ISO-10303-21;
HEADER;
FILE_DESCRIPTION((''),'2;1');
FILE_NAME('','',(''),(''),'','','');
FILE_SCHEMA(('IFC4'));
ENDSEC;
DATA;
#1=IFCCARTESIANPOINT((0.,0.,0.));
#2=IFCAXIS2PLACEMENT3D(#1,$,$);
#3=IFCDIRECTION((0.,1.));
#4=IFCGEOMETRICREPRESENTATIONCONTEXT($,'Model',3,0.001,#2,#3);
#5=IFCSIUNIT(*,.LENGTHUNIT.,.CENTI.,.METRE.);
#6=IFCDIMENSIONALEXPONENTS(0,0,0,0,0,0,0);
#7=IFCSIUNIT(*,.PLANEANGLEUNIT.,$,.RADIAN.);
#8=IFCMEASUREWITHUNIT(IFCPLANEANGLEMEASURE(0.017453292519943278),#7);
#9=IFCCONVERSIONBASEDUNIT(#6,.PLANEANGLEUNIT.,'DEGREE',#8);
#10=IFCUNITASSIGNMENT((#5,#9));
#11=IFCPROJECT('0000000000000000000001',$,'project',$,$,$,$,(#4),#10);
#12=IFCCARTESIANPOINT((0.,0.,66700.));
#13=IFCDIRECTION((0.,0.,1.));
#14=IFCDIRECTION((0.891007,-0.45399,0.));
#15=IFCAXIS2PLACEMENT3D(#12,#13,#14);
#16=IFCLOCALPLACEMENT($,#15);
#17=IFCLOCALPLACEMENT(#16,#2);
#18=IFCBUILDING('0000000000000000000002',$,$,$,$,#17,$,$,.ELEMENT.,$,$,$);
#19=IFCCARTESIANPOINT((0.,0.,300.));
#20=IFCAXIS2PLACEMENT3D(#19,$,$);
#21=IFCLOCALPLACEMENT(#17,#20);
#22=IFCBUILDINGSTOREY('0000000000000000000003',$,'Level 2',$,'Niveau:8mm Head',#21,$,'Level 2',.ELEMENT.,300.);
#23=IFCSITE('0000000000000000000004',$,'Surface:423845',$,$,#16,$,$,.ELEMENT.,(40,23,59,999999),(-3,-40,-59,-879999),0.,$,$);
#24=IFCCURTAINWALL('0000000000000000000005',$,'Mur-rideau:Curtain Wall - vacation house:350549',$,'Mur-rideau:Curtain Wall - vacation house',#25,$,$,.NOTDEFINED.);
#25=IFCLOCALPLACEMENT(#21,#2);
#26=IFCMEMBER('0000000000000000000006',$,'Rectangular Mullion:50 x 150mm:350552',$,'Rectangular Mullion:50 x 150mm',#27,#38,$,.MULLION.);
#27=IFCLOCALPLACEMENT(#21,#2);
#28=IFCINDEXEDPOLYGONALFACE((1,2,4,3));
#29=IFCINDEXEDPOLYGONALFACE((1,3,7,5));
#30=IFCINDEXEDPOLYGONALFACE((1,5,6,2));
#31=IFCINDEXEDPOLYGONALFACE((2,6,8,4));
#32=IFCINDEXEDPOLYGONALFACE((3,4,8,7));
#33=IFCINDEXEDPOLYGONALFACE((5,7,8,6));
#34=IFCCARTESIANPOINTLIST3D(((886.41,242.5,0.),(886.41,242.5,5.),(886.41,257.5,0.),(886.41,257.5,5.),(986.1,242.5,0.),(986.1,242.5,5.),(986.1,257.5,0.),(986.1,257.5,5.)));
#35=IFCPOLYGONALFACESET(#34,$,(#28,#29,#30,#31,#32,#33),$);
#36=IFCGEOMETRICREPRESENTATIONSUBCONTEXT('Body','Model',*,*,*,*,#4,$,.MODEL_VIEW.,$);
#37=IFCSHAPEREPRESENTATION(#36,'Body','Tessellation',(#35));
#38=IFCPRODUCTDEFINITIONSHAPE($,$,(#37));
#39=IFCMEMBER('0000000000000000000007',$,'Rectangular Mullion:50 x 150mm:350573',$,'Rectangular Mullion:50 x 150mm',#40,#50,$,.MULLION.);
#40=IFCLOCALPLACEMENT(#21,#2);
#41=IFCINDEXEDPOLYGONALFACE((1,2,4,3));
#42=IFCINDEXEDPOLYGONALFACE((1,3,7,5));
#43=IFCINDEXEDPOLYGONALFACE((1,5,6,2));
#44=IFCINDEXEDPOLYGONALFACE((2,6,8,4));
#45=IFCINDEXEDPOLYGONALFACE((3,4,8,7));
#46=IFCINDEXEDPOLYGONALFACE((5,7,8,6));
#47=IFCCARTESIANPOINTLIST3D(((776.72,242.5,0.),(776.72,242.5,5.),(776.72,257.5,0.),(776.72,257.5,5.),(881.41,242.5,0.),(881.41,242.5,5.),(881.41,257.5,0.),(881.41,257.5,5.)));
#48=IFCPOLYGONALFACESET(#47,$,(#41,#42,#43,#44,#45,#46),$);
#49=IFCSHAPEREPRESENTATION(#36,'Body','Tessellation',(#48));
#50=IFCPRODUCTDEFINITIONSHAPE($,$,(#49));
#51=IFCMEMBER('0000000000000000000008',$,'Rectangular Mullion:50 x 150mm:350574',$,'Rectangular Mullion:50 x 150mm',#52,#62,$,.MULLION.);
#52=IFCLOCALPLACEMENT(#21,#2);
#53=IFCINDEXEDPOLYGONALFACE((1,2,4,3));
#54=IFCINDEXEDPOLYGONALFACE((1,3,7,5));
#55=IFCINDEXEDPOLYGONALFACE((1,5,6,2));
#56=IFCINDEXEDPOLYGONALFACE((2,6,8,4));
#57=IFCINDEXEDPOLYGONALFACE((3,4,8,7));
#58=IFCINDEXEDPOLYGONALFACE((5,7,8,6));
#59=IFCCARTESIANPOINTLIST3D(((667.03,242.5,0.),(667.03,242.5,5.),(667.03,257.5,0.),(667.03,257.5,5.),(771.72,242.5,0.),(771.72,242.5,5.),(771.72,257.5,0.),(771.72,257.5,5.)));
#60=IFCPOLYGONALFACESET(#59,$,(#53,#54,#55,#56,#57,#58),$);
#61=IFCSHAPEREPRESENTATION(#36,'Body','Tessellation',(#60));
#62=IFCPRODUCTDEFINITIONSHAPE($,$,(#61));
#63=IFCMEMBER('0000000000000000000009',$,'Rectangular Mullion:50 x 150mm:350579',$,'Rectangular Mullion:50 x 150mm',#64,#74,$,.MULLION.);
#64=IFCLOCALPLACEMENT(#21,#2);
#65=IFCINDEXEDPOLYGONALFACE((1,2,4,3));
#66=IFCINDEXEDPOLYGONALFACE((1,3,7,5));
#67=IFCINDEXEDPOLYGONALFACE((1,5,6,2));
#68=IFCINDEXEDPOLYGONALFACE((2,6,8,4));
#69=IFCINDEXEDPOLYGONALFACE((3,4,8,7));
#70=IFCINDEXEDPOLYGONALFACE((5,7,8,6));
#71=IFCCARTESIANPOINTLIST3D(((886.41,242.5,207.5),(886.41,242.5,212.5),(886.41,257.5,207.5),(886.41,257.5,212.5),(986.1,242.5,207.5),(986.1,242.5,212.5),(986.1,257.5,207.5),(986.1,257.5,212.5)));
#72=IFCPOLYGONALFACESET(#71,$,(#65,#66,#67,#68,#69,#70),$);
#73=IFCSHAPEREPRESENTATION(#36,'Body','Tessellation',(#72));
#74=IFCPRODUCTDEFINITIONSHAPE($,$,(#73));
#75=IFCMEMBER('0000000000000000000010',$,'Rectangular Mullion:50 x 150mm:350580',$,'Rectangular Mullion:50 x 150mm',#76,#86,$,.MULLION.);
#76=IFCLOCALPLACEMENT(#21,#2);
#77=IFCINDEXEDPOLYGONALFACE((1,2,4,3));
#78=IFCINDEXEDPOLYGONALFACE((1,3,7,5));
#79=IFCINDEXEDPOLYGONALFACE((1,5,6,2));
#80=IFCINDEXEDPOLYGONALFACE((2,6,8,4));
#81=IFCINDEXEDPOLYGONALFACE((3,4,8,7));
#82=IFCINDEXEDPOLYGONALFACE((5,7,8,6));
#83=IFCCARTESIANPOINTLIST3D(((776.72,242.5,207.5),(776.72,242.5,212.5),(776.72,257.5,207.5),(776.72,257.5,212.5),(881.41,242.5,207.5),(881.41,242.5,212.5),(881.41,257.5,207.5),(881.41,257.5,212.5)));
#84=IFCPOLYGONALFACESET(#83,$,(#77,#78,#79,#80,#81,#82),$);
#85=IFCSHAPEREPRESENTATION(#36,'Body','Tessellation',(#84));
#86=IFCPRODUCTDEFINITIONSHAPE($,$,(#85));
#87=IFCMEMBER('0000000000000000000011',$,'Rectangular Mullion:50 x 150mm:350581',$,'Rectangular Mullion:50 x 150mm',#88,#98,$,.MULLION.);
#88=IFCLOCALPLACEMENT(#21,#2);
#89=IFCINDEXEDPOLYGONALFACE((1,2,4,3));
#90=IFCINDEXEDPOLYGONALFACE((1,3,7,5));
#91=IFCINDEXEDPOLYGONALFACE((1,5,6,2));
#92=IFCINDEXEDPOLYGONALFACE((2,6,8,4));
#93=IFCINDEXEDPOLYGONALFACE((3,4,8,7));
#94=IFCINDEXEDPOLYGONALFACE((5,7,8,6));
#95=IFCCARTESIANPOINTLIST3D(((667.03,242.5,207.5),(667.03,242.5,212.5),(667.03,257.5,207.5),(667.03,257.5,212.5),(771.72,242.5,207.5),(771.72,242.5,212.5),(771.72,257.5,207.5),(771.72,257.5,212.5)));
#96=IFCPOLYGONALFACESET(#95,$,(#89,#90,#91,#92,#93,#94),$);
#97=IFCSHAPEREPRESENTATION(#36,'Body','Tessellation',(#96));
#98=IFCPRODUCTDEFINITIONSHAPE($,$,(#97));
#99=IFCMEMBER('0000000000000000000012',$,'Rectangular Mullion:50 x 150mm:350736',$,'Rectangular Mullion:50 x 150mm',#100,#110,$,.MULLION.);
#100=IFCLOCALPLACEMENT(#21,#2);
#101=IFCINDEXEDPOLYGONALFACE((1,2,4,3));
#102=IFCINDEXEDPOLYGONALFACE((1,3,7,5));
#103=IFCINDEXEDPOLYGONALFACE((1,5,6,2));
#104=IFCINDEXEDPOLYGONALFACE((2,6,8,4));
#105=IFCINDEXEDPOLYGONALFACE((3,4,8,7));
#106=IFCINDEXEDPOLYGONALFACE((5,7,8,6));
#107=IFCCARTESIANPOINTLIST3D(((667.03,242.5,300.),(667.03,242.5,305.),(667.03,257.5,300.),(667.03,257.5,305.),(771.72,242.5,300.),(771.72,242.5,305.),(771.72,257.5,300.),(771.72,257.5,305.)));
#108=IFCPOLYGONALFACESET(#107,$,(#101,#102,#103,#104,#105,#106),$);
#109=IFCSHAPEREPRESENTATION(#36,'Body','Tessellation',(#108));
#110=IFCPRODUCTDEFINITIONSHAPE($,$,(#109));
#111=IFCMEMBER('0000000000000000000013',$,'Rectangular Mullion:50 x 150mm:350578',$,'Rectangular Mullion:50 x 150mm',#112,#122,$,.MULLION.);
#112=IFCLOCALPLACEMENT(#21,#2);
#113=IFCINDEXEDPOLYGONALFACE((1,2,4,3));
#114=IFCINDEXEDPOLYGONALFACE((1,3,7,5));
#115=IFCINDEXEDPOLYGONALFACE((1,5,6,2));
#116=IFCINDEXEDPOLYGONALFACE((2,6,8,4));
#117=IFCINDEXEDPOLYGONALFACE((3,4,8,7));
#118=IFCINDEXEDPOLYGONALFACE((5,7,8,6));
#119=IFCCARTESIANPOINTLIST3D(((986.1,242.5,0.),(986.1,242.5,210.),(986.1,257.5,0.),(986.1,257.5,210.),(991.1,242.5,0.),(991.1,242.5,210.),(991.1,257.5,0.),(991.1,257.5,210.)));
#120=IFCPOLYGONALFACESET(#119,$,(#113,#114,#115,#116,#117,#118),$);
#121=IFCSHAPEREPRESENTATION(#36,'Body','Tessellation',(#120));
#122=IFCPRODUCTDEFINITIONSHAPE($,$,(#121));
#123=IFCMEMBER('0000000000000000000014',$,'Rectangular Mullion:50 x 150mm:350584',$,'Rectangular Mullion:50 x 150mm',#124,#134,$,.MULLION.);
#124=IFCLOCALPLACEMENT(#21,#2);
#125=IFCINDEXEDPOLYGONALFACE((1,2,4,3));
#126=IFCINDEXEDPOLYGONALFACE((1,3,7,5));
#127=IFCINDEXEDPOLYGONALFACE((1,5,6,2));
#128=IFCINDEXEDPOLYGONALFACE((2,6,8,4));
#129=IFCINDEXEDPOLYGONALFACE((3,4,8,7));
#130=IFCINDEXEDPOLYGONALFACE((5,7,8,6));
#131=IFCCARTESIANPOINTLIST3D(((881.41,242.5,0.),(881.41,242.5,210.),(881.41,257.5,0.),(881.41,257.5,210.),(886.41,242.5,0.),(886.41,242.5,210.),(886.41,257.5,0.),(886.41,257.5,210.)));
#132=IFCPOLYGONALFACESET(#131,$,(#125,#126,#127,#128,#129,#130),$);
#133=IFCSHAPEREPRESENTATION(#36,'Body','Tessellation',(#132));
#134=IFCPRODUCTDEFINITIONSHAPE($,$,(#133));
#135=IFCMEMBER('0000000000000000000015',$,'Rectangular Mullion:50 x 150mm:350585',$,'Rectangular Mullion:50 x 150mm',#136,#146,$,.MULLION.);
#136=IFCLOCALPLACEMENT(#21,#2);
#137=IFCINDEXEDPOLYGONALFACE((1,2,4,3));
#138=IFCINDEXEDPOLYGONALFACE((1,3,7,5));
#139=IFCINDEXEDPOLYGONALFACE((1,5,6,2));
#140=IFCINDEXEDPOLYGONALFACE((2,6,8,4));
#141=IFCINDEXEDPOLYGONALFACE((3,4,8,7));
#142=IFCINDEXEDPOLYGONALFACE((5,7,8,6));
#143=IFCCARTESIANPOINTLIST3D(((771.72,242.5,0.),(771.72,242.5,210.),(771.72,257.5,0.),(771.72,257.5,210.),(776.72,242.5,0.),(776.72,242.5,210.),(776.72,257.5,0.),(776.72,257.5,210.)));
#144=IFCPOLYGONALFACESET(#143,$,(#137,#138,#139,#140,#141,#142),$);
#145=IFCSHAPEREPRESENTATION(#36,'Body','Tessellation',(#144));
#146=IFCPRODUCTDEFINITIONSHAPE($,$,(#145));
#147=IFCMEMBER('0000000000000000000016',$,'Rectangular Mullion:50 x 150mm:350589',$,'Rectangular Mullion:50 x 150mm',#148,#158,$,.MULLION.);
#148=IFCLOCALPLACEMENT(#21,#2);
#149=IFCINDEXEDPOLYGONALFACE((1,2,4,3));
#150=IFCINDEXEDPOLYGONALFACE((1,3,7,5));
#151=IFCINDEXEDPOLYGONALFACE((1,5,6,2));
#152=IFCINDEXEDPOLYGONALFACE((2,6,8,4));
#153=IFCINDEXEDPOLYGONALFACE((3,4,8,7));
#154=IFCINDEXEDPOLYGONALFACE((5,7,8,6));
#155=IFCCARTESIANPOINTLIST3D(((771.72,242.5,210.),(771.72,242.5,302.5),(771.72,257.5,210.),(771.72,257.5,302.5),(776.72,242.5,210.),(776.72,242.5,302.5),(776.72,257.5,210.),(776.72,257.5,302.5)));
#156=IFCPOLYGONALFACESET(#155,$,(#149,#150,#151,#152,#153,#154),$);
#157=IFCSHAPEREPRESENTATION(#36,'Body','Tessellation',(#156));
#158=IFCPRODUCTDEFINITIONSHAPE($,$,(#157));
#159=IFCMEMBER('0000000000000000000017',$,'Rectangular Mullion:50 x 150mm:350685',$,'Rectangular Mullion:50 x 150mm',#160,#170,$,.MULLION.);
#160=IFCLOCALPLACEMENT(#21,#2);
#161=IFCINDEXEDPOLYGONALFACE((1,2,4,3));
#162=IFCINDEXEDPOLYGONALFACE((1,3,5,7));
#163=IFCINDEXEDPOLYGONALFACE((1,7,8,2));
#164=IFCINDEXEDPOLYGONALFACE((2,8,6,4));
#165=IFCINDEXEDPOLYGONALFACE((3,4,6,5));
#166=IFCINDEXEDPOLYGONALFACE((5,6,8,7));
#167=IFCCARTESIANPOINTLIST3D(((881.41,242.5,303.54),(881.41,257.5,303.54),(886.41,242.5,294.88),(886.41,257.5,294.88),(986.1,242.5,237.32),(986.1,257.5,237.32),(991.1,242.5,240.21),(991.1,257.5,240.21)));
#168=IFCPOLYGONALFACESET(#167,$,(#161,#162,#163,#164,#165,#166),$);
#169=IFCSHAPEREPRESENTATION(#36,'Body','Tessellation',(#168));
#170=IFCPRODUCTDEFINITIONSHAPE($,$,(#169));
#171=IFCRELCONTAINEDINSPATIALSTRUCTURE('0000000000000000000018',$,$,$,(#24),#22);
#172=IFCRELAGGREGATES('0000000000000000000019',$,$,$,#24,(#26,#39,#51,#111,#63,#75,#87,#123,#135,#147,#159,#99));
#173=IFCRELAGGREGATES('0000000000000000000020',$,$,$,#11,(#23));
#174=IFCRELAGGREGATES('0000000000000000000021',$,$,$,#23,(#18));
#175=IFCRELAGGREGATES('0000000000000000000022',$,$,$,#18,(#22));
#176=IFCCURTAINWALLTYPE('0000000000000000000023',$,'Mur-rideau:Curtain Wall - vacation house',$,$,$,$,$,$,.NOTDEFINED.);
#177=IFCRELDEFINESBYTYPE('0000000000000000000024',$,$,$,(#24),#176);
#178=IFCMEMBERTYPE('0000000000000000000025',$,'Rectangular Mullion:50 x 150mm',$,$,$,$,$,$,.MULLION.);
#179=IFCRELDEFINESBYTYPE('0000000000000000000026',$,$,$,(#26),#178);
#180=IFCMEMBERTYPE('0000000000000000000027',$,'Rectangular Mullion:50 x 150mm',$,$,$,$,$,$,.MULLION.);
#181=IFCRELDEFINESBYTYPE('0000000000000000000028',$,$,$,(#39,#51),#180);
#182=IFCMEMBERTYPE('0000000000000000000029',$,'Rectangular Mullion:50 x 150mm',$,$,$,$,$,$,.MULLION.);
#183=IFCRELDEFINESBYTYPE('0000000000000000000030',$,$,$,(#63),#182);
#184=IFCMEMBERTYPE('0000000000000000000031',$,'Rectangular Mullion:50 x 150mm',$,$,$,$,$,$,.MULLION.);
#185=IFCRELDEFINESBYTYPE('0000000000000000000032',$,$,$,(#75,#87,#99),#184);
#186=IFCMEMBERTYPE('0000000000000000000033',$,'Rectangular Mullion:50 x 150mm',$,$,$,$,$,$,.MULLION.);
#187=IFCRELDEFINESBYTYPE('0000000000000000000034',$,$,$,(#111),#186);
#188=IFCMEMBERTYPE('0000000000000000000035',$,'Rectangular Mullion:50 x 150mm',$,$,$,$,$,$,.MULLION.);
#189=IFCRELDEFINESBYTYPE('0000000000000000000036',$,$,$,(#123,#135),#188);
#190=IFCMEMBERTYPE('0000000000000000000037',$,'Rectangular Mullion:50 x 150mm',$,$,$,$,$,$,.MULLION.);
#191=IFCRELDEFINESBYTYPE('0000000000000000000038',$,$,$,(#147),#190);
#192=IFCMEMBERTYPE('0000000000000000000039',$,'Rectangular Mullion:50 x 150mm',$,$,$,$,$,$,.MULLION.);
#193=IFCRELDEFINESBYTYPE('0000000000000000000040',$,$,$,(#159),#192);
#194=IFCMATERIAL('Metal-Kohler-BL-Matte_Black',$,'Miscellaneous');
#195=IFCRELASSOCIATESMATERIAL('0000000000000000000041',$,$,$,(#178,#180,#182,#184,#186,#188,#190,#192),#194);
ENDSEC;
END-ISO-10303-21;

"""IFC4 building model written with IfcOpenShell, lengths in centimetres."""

from ifc_helpers import new_model, entity, si_unit, converted_unit, direction, frame, origin, origin_2d_with_axis, place, context, subcontext, project, spatial, polyline, rectangle, outline, extrude, source, transform, mapped, material, material_profile, profile_set, type_object, type_shapes, element, aggregate, save


model = new_model("IFC4")

# Units and contexts
model_context = context("Model", 3, precision=0.001, world=origin(), true_north=direction((0.0, 1.0)))
body_context = subcontext(model_context, "Body", "Model", "MODEL_VIEW")
ifc_project = project(units=[si_unit("LENGTHUNIT", "METRE", prefix="CENTI"), converted_unit("PLANEANGLEUNIT", "DEGREE", entity("IfcPlaneAngleMeasure", 0.017453292519943278), si_unit("PLANEANGLEUNIT", "RADIAN"), dimensions=[0, 0, 0, 0, 0, 0, 0])], contexts=[model_context])

# Site, building, storey
site_placement = place(None, frame((0.0, 0.0, 66700.0), z_axis=(0.0, 0.0, 1.0), x_axis=(0.891007, -0.45399, 0.0)))
site = spatial("IfcSite", under=ifc_project, at=site_placement, Name="Surface:423845", CompositionType="ELEMENT", RefLatitude=(40, 23, 59, 999999), RefLongitude=(-3, -40, -59, -879999), RefElevation=0.0)
building_placement = place(site_placement, origin())
building = spatial("IfcBuilding", under=site, at=building_placement, CompositionType="ELEMENT")
storey_placement = place(building_placement, frame((0.0, 0.0, 300.0)))
storey = spatial("IfcBuildingStorey", under=building, at=storey_placement, Name="Level 2", ObjectType="Niveau:8mm Head", LongName="Level 2", CompositionType="ELEMENT", Elevation=300.0)

# Curtain wall, members
curtain_wall_type = type_object("IfcCurtainWallType", Name="Mur-rideau:Curtain Wall - vacation house", PredefinedType="NOTDEFINED")
curtain_wall_placement = place(storey_placement, frame((0.0, 0.0, -300.0)))
curtain_wall = element("IfcCurtainWall", 1, at=curtain_wall_placement, inside=storey, type_object=curtain_wall_type, Name="Mur-rideau:Curtain Wall - vacation house:350549", ObjectType="Mur-rideau:Curtain Wall - vacation house", PredefinedType="NOTDEFINED")
ifc_material_1 = material(Name="Metal-Kohler-BL-Matte_Black", Category="Miscellaneous")
ifc_material_profile = material_profile(ifc_material_1, rectangle(XDim=5.0, YDim=15.0, at=origin_2d_with_axis()), Name="50 x 150mm")
ifc_profile_set = profile_set([ifc_material_profile], Name="50 x 150mm")
member_type_1 = type_object("IfcMemberType", Name="Rectangular Mullion:50 x 150mm", PredefinedType="MULLION", material=ifc_profile_set)
shared_shape_1 = source(origin(), body_context, "Body", "SweptSolid", [
    extrude(rectangle(XDim=5.0, YDim=15.0, at=origin_2d_with_axis()), frame((-2.5, 0.0, -99.69), z_axis=(0.0, 0.0, 1.0), x_axis=(-1.0, 0.0, 0.0)), (0.0, 0.0, 1.0), 99.69),
])
type_shapes(member_type_1, [shared_shape_1])
member_1_placement = place(curtain_wall_placement, frame((986.1, 250.0, 300.0), z_axis=(1.0, 0.0, 0.0), x_axis=(0.0, 0.0, -1.0)))
member_1 = element("IfcMember", 2, at=member_1_placement, type_object=member_type_1, Name="Rectangular Mullion:50 x 150mm:350552", ObjectType="Rectangular Mullion:50 x 150mm", PredefinedType="MULLION", context=body_context, shape_type="MappedRepresentation", body=[
    mapped(shared_shape_1, transform((0.0, 0.0, 0.0), scale=1.0)),
])
member_type_2 = type_object("IfcMemberType", Name="Rectangular Mullion:50 x 150mm", PredefinedType="MULLION", material=ifc_profile_set)
shared_shape_2 = source(origin(), body_context, "Body", "SweptSolid", [
    extrude(rectangle(XDim=5.0, YDim=15.0, at=origin_2d_with_axis()), frame((-2.5, 0.0, -104.69), z_axis=(0.0, 0.0, 1.0), x_axis=(-1.0, 0.0, 0.0)), (0.0, 0.0, 1.0), 104.69),
])
type_shapes(member_type_2, [shared_shape_2])
member_2_placement = place(curtain_wall_placement, frame((881.41, 250.0, 300.0), z_axis=(1.0, 0.0, 0.0), x_axis=(0.0, 0.0, -1.0)))
member_2 = element("IfcMember", 3, at=member_2_placement, type_object=member_type_2, Name="Rectangular Mullion:50 x 150mm:350573", ObjectType="Rectangular Mullion:50 x 150mm", PredefinedType="MULLION", context=body_context, shape_type="MappedRepresentation", body=[
    mapped(shared_shape_2, transform((0.0, 0.0, 0.0), scale=1.0)),
])
member_3_placement = place(curtain_wall_placement, frame((771.72, 250.0, 300.0), z_axis=(1.0, 0.0, 0.0), x_axis=(0.0, 0.0, -1.0)))
member_3 = element("IfcMember", 4, at=member_3_placement, type_object=member_type_2, Name="Rectangular Mullion:50 x 150mm:350574", ObjectType="Rectangular Mullion:50 x 150mm", PredefinedType="MULLION", context=body_context, shape_type="MappedRepresentation", body=[
    mapped(shared_shape_2, transform((0.0, 0.0, 0.0), scale=1.0)),
])
member_type_3 = type_object("IfcMemberType", Name="Rectangular Mullion:50 x 150mm", PredefinedType="MULLION", material=ifc_profile_set)
shared_shape_3 = source(origin(), body_context, "Body", "SweptSolid", [
    extrude(rectangle(XDim=5.0, YDim=15.0, at=origin_2d_with_axis()), frame((0.0, 0.0, -99.69), z_axis=(0.0, 0.0, 1.0), x_axis=(-1.0, 0.0, 0.0)), (0.0, 0.0, 1.0), 99.69),
])
type_shapes(member_type_3, [shared_shape_3])
member_4_placement = place(curtain_wall_placement, frame((886.41, 250.0, 510.0), z_axis=(-1.0, 0.0, 0.0), x_axis=(0.0, 0.0, 1.0)))
member_4 = element("IfcMember", 5, at=member_4_placement, type_object=member_type_3, Name="Rectangular Mullion:50 x 150mm:350579", ObjectType="Rectangular Mullion:50 x 150mm", PredefinedType="MULLION", context=body_context, shape_type="MappedRepresentation", body=[
    mapped(shared_shape_3, transform((0.0, 0.0, 0.0), scale=1.0)),
])
member_type_4 = type_object("IfcMemberType", Name="Rectangular Mullion:50 x 150mm", PredefinedType="MULLION", material=ifc_profile_set)
shared_shape_4 = source(origin(), body_context, "Body", "SweptSolid", [
    extrude(rectangle(XDim=5.0, YDim=15.0, at=origin_2d_with_axis()), frame((0.0, 0.0, -104.69), z_axis=(0.0, 0.0, 1.0), x_axis=(-1.0, 0.0, 0.0)), (0.0, 0.0, 1.0), 104.69),
])
type_shapes(member_type_4, [shared_shape_4])
member_5_placement = place(curtain_wall_placement, frame((776.72, 250.0, 510.0), z_axis=(-1.0, 0.0, 0.0), x_axis=(0.0, 0.0, 1.0)))
member_5 = element("IfcMember", 6, at=member_5_placement, type_object=member_type_4, Name="Rectangular Mullion:50 x 150mm:350580", ObjectType="Rectangular Mullion:50 x 150mm", PredefinedType="MULLION", context=body_context, shape_type="MappedRepresentation", body=[
    mapped(shared_shape_4, transform((0.0, 0.0, 0.0), scale=1.0)),
])
member_6_placement = place(curtain_wall_placement, frame((667.03, 250.0, 510.0), z_axis=(-1.0, 0.0, 0.0), x_axis=(0.0, 0.0, 1.0)))
member_6 = element("IfcMember", 7, at=member_6_placement, type_object=member_type_4, Name="Rectangular Mullion:50 x 150mm:350581", ObjectType="Rectangular Mullion:50 x 150mm", PredefinedType="MULLION", context=body_context, shape_type="MappedRepresentation", body=[
    mapped(shared_shape_4, transform((0.0, 0.0, 0.0), scale=1.0)),
])
member_7_placement = place(curtain_wall_placement, frame((667.03, 250.0, 602.5), z_axis=(-1.0, 0.0, 0.0), x_axis=(0.0, 0.0, 1.0)))
member_7 = element("IfcMember", 8, at=member_7_placement, type_object=member_type_4, Name="Rectangular Mullion:50 x 150mm:350736", ObjectType="Rectangular Mullion:50 x 150mm", PredefinedType="MULLION", context=body_context, shape_type="MappedRepresentation", body=[
    mapped(shared_shape_4, transform((0.0, 0.0, 0.0), scale=1.0)),
])
member_type_5 = type_object("IfcMemberType", Name="Rectangular Mullion:50 x 150mm", PredefinedType="MULLION", material=ifc_profile_set)
shared_shape_5 = source(origin(), body_context, "Body", "SweptSolid", [
    extrude(rectangle(XDim=5.0, YDim=15.0, at=origin_2d_with_axis()), frame((-2.5, 0.0, -210.0), z_axis=(0.0, 0.0, 1.0), x_axis=(-1.0, 0.0, 0.0)), (0.0, 0.0, 1.0), 210.0),
])
type_shapes(member_type_5, [shared_shape_5])
member_8_placement = place(curtain_wall_placement, frame((991.1, 250.0, 510.0)))
member_8 = element("IfcMember", 9, at=member_8_placement, type_object=member_type_5, Name="Rectangular Mullion:50 x 150mm:350578", ObjectType="Rectangular Mullion:50 x 150mm", PredefinedType="MULLION", context=body_context, shape_type="MappedRepresentation", body=[
    mapped(shared_shape_5, transform((0.0, 0.0, 0.0), scale=1.0)),
])
member_type_6 = type_object("IfcMemberType", Name="Rectangular Mullion:50 x 150mm", PredefinedType="MULLION", material=ifc_profile_set)
shared_shape_6 = source(origin(), body_context, "Body", "SweptSolid", [
    extrude(rectangle(XDim=5.0, YDim=15.0, at=origin_2d_with_axis()), frame((0.0, 0.0, -210.0), z_axis=(0.0, 0.0, 1.0), x_axis=(-1.0, 0.0, 0.0)), (0.0, 0.0, 1.0), 210.0),
])
type_shapes(member_type_6, [shared_shape_6])
member_9_placement = place(curtain_wall_placement, frame((883.91, 250.0, 300.0), z_axis=(0.0, 0.0, -1.0), x_axis=(-1.0, 0.0, 0.0)))
member_9 = element("IfcMember", 10, at=member_9_placement, type_object=member_type_6, Name="Rectangular Mullion:50 x 150mm:350584", ObjectType="Rectangular Mullion:50 x 150mm", PredefinedType="MULLION", context=body_context, shape_type="MappedRepresentation", body=[
    mapped(shared_shape_6, transform((0.0, 0.0, 0.0), scale=1.0)),
])
member_10_placement = place(curtain_wall_placement, frame((774.22, 250.0, 300.0), z_axis=(0.0, 0.0, -1.0), x_axis=(-1.0, 0.0, 0.0)))
member_10 = element("IfcMember", 11, at=member_10_placement, type_object=member_type_6, Name="Rectangular Mullion:50 x 150mm:350585", ObjectType="Rectangular Mullion:50 x 150mm", PredefinedType="MULLION", context=body_context, shape_type="MappedRepresentation", body=[
    mapped(shared_shape_6, transform((0.0, 0.0, 0.0), scale=1.0)),
])
member_type_7 = type_object("IfcMemberType", Name="Rectangular Mullion:50 x 150mm", PredefinedType="MULLION", material=ifc_profile_set)
shared_shape_7 = source(origin(), body_context, "Body", "SweptSolid", [
    extrude(rectangle(XDim=5.0, YDim=15.0, at=origin_2d_with_axis()), frame((0.0, 0.0, -92.5), z_axis=(0.0, 0.0, 1.0), x_axis=(-1.0, 0.0, 0.0)), (0.0, 0.0, 1.0), 92.5),
])
type_shapes(member_type_7, [shared_shape_7])
member_11_placement = place(curtain_wall_placement, frame((774.22, 250.0, 510.0), z_axis=(0.0, 0.0, -1.0), x_axis=(-1.0, 0.0, 0.0)))
member_11 = element("IfcMember", 12, at=member_11_placement, type_object=member_type_7, Name="Rectangular Mullion:50 x 150mm:350589", ObjectType="Rectangular Mullion:50 x 150mm", PredefinedType="MULLION", context=body_context, shape_type="MappedRepresentation", body=[
    mapped(shared_shape_7, transform((0.0, 0.0, 0.0), scale=1.0)),
])
member_type_8 = type_object("IfcMemberType", Name="Rectangular Mullion:50 x 150mm", PredefinedType="MULLION", material=ifc_profile_set)
shared_shape_8 = source(origin(), body_context, "Body", "SweptSolid", [
    extrude(outline(polyline([(-64.77, -2.5), (61.89, -2.5), (59.0, 2.5), (-56.11, 2.5), (-64.77, -2.5)])), frame((-2.5, -7.5, -61.89), z_axis=(0.0, 1.0, 0.0), x_axis=(0.0, 0.0, -1.0)), (0.0, 0.0, 1.0), 15.0),
])
type_shapes(member_type_8, [shared_shape_8])
member_12_placement = place(curtain_wall_placement, frame((883.91, 250.0, 602.09), z_axis=(-0.866025, 0.0, 0.5), x_axis=(0.5, 0.0, 0.866025)))
member_12 = element("IfcMember", 13, at=member_12_placement, type_object=member_type_8, Name="Rectangular Mullion:50 x 150mm:350685", ObjectType="Rectangular Mullion:50 x 150mm", PredefinedType="MULLION", context=body_context, shape_type="MappedRepresentation", body=[
    mapped(shared_shape_8, transform((0.0, 0.0, 0.0), scale=1.0)),
])
aggregate(curtain_wall, [member_1, member_2, member_3, member_8, member_4, member_5, member_6, member_9, member_10, member_11, member_12, member_7])

save(model, "model.ifc")
